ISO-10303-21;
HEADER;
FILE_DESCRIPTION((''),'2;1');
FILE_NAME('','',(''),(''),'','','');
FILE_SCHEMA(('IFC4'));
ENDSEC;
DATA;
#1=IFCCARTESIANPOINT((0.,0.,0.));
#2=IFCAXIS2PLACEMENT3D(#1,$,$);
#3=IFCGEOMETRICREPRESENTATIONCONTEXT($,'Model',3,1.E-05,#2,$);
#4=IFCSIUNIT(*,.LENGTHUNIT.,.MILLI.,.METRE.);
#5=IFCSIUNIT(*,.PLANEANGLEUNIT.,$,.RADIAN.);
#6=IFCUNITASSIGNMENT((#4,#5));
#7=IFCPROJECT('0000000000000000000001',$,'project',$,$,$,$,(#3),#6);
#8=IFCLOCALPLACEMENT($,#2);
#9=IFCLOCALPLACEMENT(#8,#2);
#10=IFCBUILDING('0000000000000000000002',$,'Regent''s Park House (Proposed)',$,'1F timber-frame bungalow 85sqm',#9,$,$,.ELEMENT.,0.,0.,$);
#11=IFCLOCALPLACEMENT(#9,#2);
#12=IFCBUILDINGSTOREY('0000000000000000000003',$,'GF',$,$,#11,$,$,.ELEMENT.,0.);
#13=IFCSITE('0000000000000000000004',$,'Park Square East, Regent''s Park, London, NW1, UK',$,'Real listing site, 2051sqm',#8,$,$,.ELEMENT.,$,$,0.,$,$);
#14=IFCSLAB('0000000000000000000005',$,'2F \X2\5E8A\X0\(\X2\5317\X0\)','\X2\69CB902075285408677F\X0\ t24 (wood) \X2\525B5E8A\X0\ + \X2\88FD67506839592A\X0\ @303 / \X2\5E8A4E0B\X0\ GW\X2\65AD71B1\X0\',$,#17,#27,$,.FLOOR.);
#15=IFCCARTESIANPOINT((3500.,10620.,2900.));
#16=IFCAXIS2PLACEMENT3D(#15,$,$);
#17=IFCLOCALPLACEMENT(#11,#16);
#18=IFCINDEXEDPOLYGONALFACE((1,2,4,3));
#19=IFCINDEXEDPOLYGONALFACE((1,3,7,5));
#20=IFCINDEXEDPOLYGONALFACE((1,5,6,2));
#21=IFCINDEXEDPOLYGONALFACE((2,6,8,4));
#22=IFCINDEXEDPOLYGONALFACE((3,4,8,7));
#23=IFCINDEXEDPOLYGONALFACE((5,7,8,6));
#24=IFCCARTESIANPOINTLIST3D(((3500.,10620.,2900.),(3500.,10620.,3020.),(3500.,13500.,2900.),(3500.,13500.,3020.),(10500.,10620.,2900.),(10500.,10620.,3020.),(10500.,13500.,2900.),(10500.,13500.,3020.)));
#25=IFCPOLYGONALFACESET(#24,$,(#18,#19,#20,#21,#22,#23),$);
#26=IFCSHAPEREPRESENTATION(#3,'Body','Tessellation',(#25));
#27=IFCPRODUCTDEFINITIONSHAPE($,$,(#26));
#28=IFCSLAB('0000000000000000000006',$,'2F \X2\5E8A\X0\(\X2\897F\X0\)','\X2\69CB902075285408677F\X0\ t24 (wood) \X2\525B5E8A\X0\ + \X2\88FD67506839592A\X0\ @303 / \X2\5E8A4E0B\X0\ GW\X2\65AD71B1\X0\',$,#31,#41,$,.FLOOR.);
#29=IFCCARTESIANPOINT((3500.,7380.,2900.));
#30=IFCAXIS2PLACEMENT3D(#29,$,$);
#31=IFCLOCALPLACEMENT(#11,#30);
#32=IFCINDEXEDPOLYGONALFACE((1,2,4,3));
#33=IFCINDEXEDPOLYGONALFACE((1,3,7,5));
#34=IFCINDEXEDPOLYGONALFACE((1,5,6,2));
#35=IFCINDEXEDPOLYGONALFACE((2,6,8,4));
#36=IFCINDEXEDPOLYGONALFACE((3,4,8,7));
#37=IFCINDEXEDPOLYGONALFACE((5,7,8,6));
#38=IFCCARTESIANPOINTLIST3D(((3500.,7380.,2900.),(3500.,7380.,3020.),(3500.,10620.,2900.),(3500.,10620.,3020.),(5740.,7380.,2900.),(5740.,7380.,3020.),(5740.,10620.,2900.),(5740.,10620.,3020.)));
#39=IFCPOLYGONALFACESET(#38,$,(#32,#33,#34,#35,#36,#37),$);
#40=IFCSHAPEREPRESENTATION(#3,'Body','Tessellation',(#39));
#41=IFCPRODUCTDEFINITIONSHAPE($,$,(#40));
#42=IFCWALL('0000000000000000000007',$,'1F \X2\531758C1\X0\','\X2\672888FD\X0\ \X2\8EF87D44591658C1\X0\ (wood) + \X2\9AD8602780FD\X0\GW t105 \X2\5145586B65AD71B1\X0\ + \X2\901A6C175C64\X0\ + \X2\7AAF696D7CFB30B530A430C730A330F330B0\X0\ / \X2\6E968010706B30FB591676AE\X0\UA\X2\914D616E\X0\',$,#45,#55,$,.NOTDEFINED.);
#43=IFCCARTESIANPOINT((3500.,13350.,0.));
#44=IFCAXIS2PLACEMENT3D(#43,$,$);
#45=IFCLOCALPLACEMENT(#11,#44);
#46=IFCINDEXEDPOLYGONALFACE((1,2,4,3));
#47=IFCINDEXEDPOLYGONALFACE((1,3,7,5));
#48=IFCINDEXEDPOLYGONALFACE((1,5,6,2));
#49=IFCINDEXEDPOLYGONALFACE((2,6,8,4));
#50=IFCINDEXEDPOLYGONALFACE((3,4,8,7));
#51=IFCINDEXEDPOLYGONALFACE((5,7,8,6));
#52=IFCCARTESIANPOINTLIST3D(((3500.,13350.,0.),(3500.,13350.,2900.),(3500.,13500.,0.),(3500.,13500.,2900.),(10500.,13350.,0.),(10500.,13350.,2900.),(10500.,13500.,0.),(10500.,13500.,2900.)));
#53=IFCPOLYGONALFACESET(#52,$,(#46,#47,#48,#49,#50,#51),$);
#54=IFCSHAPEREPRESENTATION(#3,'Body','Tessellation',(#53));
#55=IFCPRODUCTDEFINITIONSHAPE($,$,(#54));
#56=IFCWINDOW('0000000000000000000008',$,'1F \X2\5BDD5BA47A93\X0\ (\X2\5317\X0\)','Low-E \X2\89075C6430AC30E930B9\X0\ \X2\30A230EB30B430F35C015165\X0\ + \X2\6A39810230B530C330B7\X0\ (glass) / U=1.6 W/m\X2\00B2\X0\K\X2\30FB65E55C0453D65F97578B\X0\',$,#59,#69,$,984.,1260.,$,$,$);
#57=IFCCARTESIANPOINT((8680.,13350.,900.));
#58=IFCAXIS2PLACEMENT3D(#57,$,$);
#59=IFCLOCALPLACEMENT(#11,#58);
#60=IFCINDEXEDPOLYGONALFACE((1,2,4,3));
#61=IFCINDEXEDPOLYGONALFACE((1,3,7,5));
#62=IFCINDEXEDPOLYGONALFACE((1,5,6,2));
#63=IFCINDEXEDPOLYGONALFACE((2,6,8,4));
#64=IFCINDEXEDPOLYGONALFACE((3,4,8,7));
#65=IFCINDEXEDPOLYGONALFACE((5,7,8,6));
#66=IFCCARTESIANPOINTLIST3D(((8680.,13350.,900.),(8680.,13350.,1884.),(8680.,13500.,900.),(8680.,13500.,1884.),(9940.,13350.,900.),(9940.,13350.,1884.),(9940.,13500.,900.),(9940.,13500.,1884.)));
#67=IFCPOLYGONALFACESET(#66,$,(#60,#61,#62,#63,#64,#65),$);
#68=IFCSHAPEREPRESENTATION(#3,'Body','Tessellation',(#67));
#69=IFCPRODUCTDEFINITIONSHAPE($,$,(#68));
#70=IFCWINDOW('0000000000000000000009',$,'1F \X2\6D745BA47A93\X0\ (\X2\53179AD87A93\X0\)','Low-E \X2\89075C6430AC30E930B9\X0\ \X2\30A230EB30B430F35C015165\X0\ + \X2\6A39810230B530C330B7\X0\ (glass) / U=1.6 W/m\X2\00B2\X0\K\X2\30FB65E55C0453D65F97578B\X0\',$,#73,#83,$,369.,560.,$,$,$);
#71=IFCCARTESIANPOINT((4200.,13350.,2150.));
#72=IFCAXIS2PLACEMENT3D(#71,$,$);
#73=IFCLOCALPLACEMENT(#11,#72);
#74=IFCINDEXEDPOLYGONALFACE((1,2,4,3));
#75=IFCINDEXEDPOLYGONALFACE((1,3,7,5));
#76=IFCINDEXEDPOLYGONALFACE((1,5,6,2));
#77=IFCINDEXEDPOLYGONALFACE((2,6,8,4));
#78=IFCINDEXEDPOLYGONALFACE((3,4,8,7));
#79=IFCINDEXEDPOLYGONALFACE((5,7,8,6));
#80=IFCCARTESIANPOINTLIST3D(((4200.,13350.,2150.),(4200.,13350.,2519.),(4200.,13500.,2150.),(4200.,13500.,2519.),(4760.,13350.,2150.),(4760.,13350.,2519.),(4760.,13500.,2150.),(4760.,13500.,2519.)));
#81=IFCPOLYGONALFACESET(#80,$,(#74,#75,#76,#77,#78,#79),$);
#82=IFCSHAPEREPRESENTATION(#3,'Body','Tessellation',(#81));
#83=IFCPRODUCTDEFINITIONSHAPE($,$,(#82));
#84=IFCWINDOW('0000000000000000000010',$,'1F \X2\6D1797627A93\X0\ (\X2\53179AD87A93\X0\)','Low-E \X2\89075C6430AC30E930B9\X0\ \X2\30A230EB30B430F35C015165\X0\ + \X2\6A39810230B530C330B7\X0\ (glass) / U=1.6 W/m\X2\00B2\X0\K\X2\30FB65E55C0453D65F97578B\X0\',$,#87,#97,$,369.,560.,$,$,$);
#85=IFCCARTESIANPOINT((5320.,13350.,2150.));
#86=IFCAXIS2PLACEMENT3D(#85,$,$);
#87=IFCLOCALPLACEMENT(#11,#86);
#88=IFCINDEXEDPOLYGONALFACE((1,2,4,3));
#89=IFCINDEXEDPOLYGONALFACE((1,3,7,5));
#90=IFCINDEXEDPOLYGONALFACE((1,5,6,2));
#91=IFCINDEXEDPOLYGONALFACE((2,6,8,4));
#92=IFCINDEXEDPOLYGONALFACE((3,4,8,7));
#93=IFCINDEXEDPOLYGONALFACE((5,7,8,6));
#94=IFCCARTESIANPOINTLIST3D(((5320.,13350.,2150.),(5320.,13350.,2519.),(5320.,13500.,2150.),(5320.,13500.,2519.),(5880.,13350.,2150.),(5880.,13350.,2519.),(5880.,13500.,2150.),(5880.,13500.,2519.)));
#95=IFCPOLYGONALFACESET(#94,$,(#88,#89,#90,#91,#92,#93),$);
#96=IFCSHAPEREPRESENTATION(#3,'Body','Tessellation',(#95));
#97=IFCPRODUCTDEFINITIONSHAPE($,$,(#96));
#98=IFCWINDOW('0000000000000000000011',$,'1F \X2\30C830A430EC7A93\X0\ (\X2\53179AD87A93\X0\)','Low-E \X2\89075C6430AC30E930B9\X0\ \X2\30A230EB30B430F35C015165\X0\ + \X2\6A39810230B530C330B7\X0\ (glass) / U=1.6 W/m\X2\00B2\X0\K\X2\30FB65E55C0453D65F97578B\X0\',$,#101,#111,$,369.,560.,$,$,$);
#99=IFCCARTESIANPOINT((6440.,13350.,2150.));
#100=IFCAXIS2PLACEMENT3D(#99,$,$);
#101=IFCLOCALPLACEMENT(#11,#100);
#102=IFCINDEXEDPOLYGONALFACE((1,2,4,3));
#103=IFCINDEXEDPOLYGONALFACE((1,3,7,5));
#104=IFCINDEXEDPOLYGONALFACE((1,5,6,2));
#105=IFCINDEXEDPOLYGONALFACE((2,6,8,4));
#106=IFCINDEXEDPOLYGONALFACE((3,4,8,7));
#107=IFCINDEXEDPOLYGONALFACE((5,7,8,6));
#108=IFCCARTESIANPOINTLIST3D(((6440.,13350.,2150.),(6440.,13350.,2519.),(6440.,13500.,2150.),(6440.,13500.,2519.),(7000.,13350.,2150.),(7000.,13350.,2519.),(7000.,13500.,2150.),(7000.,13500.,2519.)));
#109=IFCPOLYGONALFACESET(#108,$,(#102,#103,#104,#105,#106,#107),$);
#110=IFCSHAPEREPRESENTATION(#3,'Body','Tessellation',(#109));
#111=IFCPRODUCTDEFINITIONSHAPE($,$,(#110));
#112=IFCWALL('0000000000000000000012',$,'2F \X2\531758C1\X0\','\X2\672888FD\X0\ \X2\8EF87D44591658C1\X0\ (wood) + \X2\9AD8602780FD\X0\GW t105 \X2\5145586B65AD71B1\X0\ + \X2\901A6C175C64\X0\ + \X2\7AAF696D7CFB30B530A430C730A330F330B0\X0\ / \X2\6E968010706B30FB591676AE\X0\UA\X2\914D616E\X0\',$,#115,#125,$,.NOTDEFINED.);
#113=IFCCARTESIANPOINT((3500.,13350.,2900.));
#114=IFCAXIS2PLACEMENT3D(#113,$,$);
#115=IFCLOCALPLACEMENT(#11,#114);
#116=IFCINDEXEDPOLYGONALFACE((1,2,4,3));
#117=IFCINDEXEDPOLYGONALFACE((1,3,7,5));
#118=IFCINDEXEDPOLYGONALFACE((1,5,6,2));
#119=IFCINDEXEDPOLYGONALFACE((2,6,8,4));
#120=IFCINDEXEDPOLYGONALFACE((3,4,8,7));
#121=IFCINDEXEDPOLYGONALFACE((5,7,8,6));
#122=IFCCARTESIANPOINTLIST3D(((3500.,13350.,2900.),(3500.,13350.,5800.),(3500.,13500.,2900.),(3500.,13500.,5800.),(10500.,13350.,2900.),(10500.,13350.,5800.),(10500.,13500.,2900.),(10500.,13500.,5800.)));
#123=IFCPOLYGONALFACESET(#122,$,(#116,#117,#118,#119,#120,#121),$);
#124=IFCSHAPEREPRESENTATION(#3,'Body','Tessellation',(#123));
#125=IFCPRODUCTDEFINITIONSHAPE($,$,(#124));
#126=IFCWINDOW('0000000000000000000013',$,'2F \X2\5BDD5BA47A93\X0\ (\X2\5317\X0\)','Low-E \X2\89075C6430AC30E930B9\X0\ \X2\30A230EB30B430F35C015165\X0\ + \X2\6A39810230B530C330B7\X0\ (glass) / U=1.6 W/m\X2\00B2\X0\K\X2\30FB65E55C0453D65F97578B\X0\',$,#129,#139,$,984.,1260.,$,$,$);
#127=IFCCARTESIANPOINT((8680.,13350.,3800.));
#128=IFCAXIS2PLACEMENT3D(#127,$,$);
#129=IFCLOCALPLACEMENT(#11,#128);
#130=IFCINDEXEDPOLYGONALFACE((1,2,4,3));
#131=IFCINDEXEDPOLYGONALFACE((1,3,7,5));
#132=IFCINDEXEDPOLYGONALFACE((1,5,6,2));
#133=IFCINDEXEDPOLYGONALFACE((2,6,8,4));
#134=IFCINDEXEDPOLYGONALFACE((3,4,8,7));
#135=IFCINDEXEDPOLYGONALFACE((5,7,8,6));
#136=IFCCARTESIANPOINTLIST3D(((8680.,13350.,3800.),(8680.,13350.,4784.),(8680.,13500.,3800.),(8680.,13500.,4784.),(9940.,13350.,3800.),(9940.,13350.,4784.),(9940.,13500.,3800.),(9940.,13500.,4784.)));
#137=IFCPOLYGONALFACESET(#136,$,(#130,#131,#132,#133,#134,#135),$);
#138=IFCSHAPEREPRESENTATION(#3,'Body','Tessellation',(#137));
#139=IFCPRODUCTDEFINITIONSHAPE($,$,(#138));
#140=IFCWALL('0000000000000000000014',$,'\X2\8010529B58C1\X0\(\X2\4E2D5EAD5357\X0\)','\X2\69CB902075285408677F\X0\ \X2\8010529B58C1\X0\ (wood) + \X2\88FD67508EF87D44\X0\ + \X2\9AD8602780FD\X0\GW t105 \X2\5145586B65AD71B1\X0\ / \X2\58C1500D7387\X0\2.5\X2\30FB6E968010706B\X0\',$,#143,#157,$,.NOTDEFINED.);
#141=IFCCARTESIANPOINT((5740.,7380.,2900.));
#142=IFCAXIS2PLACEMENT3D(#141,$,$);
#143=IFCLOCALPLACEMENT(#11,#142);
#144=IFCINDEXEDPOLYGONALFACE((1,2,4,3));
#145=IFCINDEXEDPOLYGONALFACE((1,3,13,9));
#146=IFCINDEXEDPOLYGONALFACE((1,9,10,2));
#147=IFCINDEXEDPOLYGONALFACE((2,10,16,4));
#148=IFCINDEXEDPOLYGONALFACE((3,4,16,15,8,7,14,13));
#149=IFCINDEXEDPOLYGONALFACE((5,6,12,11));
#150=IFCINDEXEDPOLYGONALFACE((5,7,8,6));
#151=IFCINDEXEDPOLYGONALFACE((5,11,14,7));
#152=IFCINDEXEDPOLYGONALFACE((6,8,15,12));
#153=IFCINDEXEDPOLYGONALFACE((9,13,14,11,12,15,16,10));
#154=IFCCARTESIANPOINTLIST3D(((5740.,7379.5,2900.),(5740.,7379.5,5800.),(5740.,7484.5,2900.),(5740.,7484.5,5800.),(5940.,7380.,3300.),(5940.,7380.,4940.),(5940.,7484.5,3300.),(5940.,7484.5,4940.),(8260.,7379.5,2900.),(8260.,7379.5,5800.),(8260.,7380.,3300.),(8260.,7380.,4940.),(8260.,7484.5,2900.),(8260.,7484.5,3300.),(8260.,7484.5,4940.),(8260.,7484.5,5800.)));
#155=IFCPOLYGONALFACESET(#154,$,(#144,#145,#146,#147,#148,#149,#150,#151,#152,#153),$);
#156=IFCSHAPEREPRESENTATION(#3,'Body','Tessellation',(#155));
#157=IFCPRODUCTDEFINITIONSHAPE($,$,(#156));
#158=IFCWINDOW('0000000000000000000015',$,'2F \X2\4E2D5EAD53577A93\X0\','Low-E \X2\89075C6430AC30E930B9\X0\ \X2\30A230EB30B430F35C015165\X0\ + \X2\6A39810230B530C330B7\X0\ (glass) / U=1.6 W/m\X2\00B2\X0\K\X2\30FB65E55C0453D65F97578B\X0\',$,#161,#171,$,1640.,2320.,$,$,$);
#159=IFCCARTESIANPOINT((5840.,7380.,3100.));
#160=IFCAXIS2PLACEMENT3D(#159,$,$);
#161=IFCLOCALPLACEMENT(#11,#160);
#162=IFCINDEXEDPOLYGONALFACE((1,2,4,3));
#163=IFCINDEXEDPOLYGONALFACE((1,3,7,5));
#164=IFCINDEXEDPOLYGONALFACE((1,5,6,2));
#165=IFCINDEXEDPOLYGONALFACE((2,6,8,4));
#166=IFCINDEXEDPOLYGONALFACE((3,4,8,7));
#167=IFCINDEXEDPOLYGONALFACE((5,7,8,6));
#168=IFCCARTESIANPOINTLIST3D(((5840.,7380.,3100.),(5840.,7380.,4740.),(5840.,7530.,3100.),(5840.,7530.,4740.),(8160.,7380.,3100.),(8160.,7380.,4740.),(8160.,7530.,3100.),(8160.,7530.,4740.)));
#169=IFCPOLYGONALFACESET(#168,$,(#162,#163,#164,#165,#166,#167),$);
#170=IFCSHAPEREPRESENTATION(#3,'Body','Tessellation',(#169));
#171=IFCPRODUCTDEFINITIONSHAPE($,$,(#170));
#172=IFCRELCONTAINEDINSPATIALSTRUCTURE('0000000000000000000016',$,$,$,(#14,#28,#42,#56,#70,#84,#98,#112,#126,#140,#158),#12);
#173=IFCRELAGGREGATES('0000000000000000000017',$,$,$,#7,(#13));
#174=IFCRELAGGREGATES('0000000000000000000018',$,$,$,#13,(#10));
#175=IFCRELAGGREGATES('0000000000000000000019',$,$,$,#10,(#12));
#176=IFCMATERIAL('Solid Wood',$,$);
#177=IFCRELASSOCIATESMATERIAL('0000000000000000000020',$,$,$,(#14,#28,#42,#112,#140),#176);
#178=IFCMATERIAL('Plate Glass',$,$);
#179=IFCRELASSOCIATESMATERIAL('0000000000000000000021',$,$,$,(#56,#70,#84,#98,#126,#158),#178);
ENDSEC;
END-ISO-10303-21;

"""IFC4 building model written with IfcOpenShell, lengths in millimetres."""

from ifc_helpers import new_model, si_unit, frame, frame_2d, origin, place, context, project, spatial, rectangle, extrude, material, element, fill, save


model = new_model("IFC4")

# Units and contexts
model_context = context("Model", 3, precision=1e-05, world=origin())
ifc_project = project(units=[si_unit("LENGTHUNIT", "METRE", prefix="MILLI"), si_unit("PLANEANGLEUNIT", "RADIAN")], contexts=[model_context])

# Site, building, storey
site_placement = place(None, origin())
site = spatial("IfcSite", under=ifc_project, at=site_placement, Name="Park Square East, Regent's Park, London, NW1, UK", ObjectType="Real listing site, 2051sqm", CompositionType="ELEMENT", RefElevation=0.0)
building_placement = place(site_placement, origin())
building = spatial("IfcBuilding", under=site, at=building_placement, Name="Regent's Park House (Proposed)", ObjectType="1F timber-frame bungalow 85sqm", CompositionType="ELEMENT", ElevationOfRefHeight=0.0, ElevationOfTerrain=0.0)
storey_placement = place(building_placement, origin())
storey = spatial("IfcBuildingStorey", under=building, at=storey_placement, Name="GF", CompositionType="ELEMENT", Elevation=0.0)

# Slabs
ifc_material_1 = material(Name="Solid Wood")
slab_1_placement = place(storey_placement, frame((3500.0, 10620.0, 2900.0)))
element("IfcSlab", 1, at=slab_1_placement, inside=storey, material=ifc_material_1, Name="2F 床(北)", Description="構造用合板 t24 (wood) 剛床 + 製材根太 @303 / 床下 GW断熱", PredefinedType="FLOOR", context=model_context, shape_type="SweptSolid", body=[
    extrude(rectangle(XDim=7000.0, YDim=2880.0, at=frame_2d((3500.0, 1440.0))), frame((3500.0, 10620.0, 2900.0)), (0.0, 0.0, 1.0), 120.0),
])
slab_2_placement = place(storey_placement, frame((3500.0, 7380.0, 2900.0)))
element("IfcSlab", 2, at=slab_2_placement, inside=storey, material=ifc_material_1, Name="2F 床(西)", Description="構造用合板 t24 (wood) 剛床 + 製材根太 @303 / 床下 GW断熱", PredefinedType="FLOOR", context=model_context, shape_type="SweptSolid", body=[
    extrude(rectangle(XDim=2240.0, YDim=3240.0, at=frame_2d((1120.0, 1620.0))), frame((3500.0, 7380.0, 2900.0)), (0.0, 0.0, 1.0), 120.0),
])

# Wall, openings, windows
wall_1_placement = place(storey_placement, frame((3500.0, 13350.0, 0.0)))
wall_1 = element("IfcWall", 3, at=wall_1_placement, inside=storey, material=ifc_material_1, Name="1F 北壁", Description="木製 軸組外壁 (wood) + 高性能GW t105 充填断熱 + 通気層 + 窯業系サイディング / 準耐火・外皮UA配慮", PredefinedType="NOTDEFINED", context=model_context, shape_type="SweptSolid", body=[
    extrude(rectangle(XDim=7000.0, YDim=150.0, at=frame_2d((3500.0, 75.0))), frame((3500.0, 13350.0, 0.0)), (0.0, 0.0, 1.0), 2900.0),
])
opening_1_placement = place(storey_placement, frame((8680.0, 13350.0, 900.0)))
opening_1 = element("IfcOpeningElement", 4, at=opening_1_placement, cuts=wall_1, PredefinedType="NOTDEFINED", context=model_context, shape_type="SweptSolid", body=[
    extrude(rectangle(XDim=1260.0, YDim=150.0, at=frame_2d((630.0, 75.0))), frame((8680.0, 13350.0, 900.0)), (0.0, 0.0, 1.0), 984.0),
])
opening_2_placement = place(storey_placement, frame((4200.0, 13350.0, 2150.0)))
opening_2 = element("IfcOpeningElement", 5, at=opening_2_placement, cuts=wall_1, PredefinedType="NOTDEFINED", context=model_context, shape_type="SweptSolid", body=[
    extrude(rectangle(XDim=560.0, YDim=150.0, at=frame_2d((280.0, 75.0))), frame((4200.0, 13350.0, 2150.0)), (0.0, 0.0, 1.0), 369.0),
])
opening_3_placement = place(storey_placement, frame((5320.0, 13350.0, 2150.0)))
opening_3 = element("IfcOpeningElement", 6, at=opening_3_placement, cuts=wall_1, PredefinedType="NOTDEFINED", context=model_context, shape_type="SweptSolid", body=[
    extrude(rectangle(XDim=560.0, YDim=150.0, at=frame_2d((280.0, 75.0))), frame((5320.0, 13350.0, 2150.0)), (0.0, 0.0, 1.0), 369.0),
])
opening_4_placement = place(storey_placement, frame((6440.0, 13350.0, 2150.0)))
opening_4 = element("IfcOpeningElement", 7, at=opening_4_placement, cuts=wall_1, PredefinedType="NOTDEFINED", context=model_context, shape_type="SweptSolid", body=[
    extrude(rectangle(XDim=560.0, YDim=150.0, at=frame_2d((280.0, 75.0))), frame((6440.0, 13350.0, 2150.0)), (0.0, 0.0, 1.0), 369.0),
])
ifc_material_2 = material(Name="Plate Glass")
window_1_placement = place(storey_placement, frame((8680.0, 13350.0, 900.0)))
window_1 = element("IfcWindow", 8, at=window_1_placement, inside=storey, material=ifc_material_2, Name="1F 寝室窓 (北)", Description="Low-E 複層ガラス アルゴン封入 + 樹脂サッシ (glass) / U=1.6 W/m²K・日射取得型", OverallHeight=984.0, OverallWidth=1260.0, context=model_context, shape_type="SweptSolid", body=[
    extrude(rectangle(XDim=1260.0, YDim=150.0, at=frame_2d((630.0, 75.0))), frame((8680.0, 13350.0, 900.0)), (0.0, 0.0, 1.0), 984.0),
])
fill(opening_1, window_1)
window_2_placement = place(storey_placement, frame((4200.0, 13350.0, 2150.0)))
window_2 = element("IfcWindow", 9, at=window_2_placement, inside=storey, material=ifc_material_2, Name="1F 浴室窓 (北高窓)", Description="Low-E 複層ガラス アルゴン封入 + 樹脂サッシ (glass) / U=1.6 W/m²K・日射取得型", OverallHeight=369.0, OverallWidth=560.0, context=model_context, shape_type="SweptSolid", body=[
    extrude(rectangle(XDim=560.0, YDim=150.0, at=frame_2d((280.0, 75.0))), frame((4200.0, 13350.0, 2150.0)), (0.0, 0.0, 1.0), 369.0),
])
fill(opening_2, window_2)
window_3_placement = place(storey_placement, frame((5320.0, 13350.0, 2150.0)))
window_3 = element("IfcWindow", 10, at=window_3_placement, inside=storey, material=ifc_material_2, Name="1F 洗面窓 (北高窓)", Description="Low-E 複層ガラス アルゴン封入 + 樹脂サッシ (glass) / U=1.6 W/m²K・日射取得型", OverallHeight=369.0, OverallWidth=560.0, context=model_context, shape_type="SweptSolid", body=[
    extrude(rectangle(XDim=560.0, YDim=150.0, at=frame_2d((280.0, 75.0))), frame((5320.0, 13350.0, 2150.0)), (0.0, 0.0, 1.0), 369.0),
])
fill(opening_3, window_3)
window_4_placement = place(storey_placement, frame((6440.0, 13350.0, 2150.0)))
window_4 = element("IfcWindow", 11, at=window_4_placement, inside=storey, material=ifc_material_2, Name="1F トイレ窓 (北高窓)", Description="Low-E 複層ガラス アルゴン封入 + 樹脂サッシ (glass) / U=1.6 W/m²K・日射取得型", OverallHeight=369.0, OverallWidth=560.0, context=model_context, shape_type="SweptSolid", body=[
    extrude(rectangle(XDim=560.0, YDim=150.0, at=frame_2d((280.0, 75.0))), frame((6440.0, 13350.0, 2150.0)), (0.0, 0.0, 1.0), 369.0),
])
fill(opening_4, window_4)

# Walls, openings, windows
wall_2_placement = place(storey_placement, frame((3500.0, 13350.0, 2900.0)))
wall_2 = element("IfcWall", 12, at=wall_2_placement, inside=storey, material=ifc_material_1, Name="2F 北壁", Description="木製 軸組外壁 (wood) + 高性能GW t105 充填断熱 + 通気層 + 窯業系サイディング / 準耐火・外皮UA配慮", PredefinedType="NOTDEFINED", context=model_context, shape_type="SweptSolid", body=[
    extrude(rectangle(XDim=7000.0, YDim=150.0, at=frame_2d((3500.0, 75.0))), frame((3500.0, 13350.0, 2900.0)), (0.0, 0.0, 1.0), 2900.0),
])
opening_5_placement = place(storey_placement, frame((8680.0, 13350.0, 3800.0)))
opening_5 = element("IfcOpeningElement", 13, at=opening_5_placement, cuts=wall_2, PredefinedType="NOTDEFINED", context=model_context, shape_type="SweptSolid", body=[
    extrude(rectangle(XDim=1260.0, YDim=150.0, at=frame_2d((630.0, 75.0))), frame((8680.0, 13350.0, 3800.0)), (0.0, 0.0, 1.0), 984.0),
])
window_5_placement = place(storey_placement, frame((8680.0, 13350.0, 3800.0)))
window_5 = element("IfcWindow", 14, at=window_5_placement, inside=storey, material=ifc_material_2, Name="2F 寝室窓 (北)", Description="Low-E 複層ガラス アルゴン封入 + 樹脂サッシ (glass) / U=1.6 W/m²K・日射取得型", OverallHeight=984.0, OverallWidth=1260.0, context=model_context, shape_type="SweptSolid", body=[
    extrude(rectangle(XDim=1260.0, YDim=150.0, at=frame_2d((630.0, 75.0))), frame((8680.0, 13350.0, 3800.0)), (0.0, 0.0, 1.0), 984.0),
])
fill(opening_5, window_5)
wall_3_placement = place(storey_placement, frame((5740.0, 7380.0, 2900.0)))
wall_3 = element("IfcWall", 15, at=wall_3_placement, inside=storey, material=ifc_material_1, Name="耐力壁(中庭南)", Description="構造用合板 耐力壁 (wood) + 製材軸組 + 高性能GW t105 充填断熱 / 壁倍率2.5・準耐火", PredefinedType="NOTDEFINED", context=model_context, shape_type="SweptSolid", body=[
    extrude(rectangle(XDim=2520.0, YDim=105.0, at=frame_2d((1260.0, 52.0))), frame((5740.0, 7380.0, 2900.0)), (0.0, 0.0, 1.0), 2900.0),
])
opening_6_placement = place(storey_placement, frame((5840.0, 7380.0, 3100.0)))
opening_6 = element("IfcOpeningElement", 16, at=opening_6_placement, cuts=wall_3, PredefinedType="NOTDEFINED", context=model_context, shape_type="SweptSolid", body=[
    extrude(rectangle(XDim=2320.0, YDim=150.0, at=frame_2d((1160.0, 75.0))), frame((5840.0, 7380.0, 3100.0)), (0.0, 0.0, 1.0), 1640.0),
])
window_6_placement = place(storey_placement, frame((5840.0, 7380.0, 3100.0)))
window_6 = element("IfcWindow", 17, at=window_6_placement, inside=storey, material=ifc_material_2, Name="2F 中庭南窓", Description="Low-E 複層ガラス アルゴン封入 + 樹脂サッシ (glass) / U=1.6 W/m²K・日射取得型", OverallHeight=1640.0, OverallWidth=2320.0, context=model_context, shape_type="SweptSolid", body=[
    extrude(rectangle(XDim=2320.0, YDim=150.0, at=frame_2d((1160.0, 75.0))), frame((5840.0, 7380.0, 3100.0)), (0.0, 0.0, 1.0), 1640.0),
])
fill(opening_6, window_6)

save(model, "model.ifc")
